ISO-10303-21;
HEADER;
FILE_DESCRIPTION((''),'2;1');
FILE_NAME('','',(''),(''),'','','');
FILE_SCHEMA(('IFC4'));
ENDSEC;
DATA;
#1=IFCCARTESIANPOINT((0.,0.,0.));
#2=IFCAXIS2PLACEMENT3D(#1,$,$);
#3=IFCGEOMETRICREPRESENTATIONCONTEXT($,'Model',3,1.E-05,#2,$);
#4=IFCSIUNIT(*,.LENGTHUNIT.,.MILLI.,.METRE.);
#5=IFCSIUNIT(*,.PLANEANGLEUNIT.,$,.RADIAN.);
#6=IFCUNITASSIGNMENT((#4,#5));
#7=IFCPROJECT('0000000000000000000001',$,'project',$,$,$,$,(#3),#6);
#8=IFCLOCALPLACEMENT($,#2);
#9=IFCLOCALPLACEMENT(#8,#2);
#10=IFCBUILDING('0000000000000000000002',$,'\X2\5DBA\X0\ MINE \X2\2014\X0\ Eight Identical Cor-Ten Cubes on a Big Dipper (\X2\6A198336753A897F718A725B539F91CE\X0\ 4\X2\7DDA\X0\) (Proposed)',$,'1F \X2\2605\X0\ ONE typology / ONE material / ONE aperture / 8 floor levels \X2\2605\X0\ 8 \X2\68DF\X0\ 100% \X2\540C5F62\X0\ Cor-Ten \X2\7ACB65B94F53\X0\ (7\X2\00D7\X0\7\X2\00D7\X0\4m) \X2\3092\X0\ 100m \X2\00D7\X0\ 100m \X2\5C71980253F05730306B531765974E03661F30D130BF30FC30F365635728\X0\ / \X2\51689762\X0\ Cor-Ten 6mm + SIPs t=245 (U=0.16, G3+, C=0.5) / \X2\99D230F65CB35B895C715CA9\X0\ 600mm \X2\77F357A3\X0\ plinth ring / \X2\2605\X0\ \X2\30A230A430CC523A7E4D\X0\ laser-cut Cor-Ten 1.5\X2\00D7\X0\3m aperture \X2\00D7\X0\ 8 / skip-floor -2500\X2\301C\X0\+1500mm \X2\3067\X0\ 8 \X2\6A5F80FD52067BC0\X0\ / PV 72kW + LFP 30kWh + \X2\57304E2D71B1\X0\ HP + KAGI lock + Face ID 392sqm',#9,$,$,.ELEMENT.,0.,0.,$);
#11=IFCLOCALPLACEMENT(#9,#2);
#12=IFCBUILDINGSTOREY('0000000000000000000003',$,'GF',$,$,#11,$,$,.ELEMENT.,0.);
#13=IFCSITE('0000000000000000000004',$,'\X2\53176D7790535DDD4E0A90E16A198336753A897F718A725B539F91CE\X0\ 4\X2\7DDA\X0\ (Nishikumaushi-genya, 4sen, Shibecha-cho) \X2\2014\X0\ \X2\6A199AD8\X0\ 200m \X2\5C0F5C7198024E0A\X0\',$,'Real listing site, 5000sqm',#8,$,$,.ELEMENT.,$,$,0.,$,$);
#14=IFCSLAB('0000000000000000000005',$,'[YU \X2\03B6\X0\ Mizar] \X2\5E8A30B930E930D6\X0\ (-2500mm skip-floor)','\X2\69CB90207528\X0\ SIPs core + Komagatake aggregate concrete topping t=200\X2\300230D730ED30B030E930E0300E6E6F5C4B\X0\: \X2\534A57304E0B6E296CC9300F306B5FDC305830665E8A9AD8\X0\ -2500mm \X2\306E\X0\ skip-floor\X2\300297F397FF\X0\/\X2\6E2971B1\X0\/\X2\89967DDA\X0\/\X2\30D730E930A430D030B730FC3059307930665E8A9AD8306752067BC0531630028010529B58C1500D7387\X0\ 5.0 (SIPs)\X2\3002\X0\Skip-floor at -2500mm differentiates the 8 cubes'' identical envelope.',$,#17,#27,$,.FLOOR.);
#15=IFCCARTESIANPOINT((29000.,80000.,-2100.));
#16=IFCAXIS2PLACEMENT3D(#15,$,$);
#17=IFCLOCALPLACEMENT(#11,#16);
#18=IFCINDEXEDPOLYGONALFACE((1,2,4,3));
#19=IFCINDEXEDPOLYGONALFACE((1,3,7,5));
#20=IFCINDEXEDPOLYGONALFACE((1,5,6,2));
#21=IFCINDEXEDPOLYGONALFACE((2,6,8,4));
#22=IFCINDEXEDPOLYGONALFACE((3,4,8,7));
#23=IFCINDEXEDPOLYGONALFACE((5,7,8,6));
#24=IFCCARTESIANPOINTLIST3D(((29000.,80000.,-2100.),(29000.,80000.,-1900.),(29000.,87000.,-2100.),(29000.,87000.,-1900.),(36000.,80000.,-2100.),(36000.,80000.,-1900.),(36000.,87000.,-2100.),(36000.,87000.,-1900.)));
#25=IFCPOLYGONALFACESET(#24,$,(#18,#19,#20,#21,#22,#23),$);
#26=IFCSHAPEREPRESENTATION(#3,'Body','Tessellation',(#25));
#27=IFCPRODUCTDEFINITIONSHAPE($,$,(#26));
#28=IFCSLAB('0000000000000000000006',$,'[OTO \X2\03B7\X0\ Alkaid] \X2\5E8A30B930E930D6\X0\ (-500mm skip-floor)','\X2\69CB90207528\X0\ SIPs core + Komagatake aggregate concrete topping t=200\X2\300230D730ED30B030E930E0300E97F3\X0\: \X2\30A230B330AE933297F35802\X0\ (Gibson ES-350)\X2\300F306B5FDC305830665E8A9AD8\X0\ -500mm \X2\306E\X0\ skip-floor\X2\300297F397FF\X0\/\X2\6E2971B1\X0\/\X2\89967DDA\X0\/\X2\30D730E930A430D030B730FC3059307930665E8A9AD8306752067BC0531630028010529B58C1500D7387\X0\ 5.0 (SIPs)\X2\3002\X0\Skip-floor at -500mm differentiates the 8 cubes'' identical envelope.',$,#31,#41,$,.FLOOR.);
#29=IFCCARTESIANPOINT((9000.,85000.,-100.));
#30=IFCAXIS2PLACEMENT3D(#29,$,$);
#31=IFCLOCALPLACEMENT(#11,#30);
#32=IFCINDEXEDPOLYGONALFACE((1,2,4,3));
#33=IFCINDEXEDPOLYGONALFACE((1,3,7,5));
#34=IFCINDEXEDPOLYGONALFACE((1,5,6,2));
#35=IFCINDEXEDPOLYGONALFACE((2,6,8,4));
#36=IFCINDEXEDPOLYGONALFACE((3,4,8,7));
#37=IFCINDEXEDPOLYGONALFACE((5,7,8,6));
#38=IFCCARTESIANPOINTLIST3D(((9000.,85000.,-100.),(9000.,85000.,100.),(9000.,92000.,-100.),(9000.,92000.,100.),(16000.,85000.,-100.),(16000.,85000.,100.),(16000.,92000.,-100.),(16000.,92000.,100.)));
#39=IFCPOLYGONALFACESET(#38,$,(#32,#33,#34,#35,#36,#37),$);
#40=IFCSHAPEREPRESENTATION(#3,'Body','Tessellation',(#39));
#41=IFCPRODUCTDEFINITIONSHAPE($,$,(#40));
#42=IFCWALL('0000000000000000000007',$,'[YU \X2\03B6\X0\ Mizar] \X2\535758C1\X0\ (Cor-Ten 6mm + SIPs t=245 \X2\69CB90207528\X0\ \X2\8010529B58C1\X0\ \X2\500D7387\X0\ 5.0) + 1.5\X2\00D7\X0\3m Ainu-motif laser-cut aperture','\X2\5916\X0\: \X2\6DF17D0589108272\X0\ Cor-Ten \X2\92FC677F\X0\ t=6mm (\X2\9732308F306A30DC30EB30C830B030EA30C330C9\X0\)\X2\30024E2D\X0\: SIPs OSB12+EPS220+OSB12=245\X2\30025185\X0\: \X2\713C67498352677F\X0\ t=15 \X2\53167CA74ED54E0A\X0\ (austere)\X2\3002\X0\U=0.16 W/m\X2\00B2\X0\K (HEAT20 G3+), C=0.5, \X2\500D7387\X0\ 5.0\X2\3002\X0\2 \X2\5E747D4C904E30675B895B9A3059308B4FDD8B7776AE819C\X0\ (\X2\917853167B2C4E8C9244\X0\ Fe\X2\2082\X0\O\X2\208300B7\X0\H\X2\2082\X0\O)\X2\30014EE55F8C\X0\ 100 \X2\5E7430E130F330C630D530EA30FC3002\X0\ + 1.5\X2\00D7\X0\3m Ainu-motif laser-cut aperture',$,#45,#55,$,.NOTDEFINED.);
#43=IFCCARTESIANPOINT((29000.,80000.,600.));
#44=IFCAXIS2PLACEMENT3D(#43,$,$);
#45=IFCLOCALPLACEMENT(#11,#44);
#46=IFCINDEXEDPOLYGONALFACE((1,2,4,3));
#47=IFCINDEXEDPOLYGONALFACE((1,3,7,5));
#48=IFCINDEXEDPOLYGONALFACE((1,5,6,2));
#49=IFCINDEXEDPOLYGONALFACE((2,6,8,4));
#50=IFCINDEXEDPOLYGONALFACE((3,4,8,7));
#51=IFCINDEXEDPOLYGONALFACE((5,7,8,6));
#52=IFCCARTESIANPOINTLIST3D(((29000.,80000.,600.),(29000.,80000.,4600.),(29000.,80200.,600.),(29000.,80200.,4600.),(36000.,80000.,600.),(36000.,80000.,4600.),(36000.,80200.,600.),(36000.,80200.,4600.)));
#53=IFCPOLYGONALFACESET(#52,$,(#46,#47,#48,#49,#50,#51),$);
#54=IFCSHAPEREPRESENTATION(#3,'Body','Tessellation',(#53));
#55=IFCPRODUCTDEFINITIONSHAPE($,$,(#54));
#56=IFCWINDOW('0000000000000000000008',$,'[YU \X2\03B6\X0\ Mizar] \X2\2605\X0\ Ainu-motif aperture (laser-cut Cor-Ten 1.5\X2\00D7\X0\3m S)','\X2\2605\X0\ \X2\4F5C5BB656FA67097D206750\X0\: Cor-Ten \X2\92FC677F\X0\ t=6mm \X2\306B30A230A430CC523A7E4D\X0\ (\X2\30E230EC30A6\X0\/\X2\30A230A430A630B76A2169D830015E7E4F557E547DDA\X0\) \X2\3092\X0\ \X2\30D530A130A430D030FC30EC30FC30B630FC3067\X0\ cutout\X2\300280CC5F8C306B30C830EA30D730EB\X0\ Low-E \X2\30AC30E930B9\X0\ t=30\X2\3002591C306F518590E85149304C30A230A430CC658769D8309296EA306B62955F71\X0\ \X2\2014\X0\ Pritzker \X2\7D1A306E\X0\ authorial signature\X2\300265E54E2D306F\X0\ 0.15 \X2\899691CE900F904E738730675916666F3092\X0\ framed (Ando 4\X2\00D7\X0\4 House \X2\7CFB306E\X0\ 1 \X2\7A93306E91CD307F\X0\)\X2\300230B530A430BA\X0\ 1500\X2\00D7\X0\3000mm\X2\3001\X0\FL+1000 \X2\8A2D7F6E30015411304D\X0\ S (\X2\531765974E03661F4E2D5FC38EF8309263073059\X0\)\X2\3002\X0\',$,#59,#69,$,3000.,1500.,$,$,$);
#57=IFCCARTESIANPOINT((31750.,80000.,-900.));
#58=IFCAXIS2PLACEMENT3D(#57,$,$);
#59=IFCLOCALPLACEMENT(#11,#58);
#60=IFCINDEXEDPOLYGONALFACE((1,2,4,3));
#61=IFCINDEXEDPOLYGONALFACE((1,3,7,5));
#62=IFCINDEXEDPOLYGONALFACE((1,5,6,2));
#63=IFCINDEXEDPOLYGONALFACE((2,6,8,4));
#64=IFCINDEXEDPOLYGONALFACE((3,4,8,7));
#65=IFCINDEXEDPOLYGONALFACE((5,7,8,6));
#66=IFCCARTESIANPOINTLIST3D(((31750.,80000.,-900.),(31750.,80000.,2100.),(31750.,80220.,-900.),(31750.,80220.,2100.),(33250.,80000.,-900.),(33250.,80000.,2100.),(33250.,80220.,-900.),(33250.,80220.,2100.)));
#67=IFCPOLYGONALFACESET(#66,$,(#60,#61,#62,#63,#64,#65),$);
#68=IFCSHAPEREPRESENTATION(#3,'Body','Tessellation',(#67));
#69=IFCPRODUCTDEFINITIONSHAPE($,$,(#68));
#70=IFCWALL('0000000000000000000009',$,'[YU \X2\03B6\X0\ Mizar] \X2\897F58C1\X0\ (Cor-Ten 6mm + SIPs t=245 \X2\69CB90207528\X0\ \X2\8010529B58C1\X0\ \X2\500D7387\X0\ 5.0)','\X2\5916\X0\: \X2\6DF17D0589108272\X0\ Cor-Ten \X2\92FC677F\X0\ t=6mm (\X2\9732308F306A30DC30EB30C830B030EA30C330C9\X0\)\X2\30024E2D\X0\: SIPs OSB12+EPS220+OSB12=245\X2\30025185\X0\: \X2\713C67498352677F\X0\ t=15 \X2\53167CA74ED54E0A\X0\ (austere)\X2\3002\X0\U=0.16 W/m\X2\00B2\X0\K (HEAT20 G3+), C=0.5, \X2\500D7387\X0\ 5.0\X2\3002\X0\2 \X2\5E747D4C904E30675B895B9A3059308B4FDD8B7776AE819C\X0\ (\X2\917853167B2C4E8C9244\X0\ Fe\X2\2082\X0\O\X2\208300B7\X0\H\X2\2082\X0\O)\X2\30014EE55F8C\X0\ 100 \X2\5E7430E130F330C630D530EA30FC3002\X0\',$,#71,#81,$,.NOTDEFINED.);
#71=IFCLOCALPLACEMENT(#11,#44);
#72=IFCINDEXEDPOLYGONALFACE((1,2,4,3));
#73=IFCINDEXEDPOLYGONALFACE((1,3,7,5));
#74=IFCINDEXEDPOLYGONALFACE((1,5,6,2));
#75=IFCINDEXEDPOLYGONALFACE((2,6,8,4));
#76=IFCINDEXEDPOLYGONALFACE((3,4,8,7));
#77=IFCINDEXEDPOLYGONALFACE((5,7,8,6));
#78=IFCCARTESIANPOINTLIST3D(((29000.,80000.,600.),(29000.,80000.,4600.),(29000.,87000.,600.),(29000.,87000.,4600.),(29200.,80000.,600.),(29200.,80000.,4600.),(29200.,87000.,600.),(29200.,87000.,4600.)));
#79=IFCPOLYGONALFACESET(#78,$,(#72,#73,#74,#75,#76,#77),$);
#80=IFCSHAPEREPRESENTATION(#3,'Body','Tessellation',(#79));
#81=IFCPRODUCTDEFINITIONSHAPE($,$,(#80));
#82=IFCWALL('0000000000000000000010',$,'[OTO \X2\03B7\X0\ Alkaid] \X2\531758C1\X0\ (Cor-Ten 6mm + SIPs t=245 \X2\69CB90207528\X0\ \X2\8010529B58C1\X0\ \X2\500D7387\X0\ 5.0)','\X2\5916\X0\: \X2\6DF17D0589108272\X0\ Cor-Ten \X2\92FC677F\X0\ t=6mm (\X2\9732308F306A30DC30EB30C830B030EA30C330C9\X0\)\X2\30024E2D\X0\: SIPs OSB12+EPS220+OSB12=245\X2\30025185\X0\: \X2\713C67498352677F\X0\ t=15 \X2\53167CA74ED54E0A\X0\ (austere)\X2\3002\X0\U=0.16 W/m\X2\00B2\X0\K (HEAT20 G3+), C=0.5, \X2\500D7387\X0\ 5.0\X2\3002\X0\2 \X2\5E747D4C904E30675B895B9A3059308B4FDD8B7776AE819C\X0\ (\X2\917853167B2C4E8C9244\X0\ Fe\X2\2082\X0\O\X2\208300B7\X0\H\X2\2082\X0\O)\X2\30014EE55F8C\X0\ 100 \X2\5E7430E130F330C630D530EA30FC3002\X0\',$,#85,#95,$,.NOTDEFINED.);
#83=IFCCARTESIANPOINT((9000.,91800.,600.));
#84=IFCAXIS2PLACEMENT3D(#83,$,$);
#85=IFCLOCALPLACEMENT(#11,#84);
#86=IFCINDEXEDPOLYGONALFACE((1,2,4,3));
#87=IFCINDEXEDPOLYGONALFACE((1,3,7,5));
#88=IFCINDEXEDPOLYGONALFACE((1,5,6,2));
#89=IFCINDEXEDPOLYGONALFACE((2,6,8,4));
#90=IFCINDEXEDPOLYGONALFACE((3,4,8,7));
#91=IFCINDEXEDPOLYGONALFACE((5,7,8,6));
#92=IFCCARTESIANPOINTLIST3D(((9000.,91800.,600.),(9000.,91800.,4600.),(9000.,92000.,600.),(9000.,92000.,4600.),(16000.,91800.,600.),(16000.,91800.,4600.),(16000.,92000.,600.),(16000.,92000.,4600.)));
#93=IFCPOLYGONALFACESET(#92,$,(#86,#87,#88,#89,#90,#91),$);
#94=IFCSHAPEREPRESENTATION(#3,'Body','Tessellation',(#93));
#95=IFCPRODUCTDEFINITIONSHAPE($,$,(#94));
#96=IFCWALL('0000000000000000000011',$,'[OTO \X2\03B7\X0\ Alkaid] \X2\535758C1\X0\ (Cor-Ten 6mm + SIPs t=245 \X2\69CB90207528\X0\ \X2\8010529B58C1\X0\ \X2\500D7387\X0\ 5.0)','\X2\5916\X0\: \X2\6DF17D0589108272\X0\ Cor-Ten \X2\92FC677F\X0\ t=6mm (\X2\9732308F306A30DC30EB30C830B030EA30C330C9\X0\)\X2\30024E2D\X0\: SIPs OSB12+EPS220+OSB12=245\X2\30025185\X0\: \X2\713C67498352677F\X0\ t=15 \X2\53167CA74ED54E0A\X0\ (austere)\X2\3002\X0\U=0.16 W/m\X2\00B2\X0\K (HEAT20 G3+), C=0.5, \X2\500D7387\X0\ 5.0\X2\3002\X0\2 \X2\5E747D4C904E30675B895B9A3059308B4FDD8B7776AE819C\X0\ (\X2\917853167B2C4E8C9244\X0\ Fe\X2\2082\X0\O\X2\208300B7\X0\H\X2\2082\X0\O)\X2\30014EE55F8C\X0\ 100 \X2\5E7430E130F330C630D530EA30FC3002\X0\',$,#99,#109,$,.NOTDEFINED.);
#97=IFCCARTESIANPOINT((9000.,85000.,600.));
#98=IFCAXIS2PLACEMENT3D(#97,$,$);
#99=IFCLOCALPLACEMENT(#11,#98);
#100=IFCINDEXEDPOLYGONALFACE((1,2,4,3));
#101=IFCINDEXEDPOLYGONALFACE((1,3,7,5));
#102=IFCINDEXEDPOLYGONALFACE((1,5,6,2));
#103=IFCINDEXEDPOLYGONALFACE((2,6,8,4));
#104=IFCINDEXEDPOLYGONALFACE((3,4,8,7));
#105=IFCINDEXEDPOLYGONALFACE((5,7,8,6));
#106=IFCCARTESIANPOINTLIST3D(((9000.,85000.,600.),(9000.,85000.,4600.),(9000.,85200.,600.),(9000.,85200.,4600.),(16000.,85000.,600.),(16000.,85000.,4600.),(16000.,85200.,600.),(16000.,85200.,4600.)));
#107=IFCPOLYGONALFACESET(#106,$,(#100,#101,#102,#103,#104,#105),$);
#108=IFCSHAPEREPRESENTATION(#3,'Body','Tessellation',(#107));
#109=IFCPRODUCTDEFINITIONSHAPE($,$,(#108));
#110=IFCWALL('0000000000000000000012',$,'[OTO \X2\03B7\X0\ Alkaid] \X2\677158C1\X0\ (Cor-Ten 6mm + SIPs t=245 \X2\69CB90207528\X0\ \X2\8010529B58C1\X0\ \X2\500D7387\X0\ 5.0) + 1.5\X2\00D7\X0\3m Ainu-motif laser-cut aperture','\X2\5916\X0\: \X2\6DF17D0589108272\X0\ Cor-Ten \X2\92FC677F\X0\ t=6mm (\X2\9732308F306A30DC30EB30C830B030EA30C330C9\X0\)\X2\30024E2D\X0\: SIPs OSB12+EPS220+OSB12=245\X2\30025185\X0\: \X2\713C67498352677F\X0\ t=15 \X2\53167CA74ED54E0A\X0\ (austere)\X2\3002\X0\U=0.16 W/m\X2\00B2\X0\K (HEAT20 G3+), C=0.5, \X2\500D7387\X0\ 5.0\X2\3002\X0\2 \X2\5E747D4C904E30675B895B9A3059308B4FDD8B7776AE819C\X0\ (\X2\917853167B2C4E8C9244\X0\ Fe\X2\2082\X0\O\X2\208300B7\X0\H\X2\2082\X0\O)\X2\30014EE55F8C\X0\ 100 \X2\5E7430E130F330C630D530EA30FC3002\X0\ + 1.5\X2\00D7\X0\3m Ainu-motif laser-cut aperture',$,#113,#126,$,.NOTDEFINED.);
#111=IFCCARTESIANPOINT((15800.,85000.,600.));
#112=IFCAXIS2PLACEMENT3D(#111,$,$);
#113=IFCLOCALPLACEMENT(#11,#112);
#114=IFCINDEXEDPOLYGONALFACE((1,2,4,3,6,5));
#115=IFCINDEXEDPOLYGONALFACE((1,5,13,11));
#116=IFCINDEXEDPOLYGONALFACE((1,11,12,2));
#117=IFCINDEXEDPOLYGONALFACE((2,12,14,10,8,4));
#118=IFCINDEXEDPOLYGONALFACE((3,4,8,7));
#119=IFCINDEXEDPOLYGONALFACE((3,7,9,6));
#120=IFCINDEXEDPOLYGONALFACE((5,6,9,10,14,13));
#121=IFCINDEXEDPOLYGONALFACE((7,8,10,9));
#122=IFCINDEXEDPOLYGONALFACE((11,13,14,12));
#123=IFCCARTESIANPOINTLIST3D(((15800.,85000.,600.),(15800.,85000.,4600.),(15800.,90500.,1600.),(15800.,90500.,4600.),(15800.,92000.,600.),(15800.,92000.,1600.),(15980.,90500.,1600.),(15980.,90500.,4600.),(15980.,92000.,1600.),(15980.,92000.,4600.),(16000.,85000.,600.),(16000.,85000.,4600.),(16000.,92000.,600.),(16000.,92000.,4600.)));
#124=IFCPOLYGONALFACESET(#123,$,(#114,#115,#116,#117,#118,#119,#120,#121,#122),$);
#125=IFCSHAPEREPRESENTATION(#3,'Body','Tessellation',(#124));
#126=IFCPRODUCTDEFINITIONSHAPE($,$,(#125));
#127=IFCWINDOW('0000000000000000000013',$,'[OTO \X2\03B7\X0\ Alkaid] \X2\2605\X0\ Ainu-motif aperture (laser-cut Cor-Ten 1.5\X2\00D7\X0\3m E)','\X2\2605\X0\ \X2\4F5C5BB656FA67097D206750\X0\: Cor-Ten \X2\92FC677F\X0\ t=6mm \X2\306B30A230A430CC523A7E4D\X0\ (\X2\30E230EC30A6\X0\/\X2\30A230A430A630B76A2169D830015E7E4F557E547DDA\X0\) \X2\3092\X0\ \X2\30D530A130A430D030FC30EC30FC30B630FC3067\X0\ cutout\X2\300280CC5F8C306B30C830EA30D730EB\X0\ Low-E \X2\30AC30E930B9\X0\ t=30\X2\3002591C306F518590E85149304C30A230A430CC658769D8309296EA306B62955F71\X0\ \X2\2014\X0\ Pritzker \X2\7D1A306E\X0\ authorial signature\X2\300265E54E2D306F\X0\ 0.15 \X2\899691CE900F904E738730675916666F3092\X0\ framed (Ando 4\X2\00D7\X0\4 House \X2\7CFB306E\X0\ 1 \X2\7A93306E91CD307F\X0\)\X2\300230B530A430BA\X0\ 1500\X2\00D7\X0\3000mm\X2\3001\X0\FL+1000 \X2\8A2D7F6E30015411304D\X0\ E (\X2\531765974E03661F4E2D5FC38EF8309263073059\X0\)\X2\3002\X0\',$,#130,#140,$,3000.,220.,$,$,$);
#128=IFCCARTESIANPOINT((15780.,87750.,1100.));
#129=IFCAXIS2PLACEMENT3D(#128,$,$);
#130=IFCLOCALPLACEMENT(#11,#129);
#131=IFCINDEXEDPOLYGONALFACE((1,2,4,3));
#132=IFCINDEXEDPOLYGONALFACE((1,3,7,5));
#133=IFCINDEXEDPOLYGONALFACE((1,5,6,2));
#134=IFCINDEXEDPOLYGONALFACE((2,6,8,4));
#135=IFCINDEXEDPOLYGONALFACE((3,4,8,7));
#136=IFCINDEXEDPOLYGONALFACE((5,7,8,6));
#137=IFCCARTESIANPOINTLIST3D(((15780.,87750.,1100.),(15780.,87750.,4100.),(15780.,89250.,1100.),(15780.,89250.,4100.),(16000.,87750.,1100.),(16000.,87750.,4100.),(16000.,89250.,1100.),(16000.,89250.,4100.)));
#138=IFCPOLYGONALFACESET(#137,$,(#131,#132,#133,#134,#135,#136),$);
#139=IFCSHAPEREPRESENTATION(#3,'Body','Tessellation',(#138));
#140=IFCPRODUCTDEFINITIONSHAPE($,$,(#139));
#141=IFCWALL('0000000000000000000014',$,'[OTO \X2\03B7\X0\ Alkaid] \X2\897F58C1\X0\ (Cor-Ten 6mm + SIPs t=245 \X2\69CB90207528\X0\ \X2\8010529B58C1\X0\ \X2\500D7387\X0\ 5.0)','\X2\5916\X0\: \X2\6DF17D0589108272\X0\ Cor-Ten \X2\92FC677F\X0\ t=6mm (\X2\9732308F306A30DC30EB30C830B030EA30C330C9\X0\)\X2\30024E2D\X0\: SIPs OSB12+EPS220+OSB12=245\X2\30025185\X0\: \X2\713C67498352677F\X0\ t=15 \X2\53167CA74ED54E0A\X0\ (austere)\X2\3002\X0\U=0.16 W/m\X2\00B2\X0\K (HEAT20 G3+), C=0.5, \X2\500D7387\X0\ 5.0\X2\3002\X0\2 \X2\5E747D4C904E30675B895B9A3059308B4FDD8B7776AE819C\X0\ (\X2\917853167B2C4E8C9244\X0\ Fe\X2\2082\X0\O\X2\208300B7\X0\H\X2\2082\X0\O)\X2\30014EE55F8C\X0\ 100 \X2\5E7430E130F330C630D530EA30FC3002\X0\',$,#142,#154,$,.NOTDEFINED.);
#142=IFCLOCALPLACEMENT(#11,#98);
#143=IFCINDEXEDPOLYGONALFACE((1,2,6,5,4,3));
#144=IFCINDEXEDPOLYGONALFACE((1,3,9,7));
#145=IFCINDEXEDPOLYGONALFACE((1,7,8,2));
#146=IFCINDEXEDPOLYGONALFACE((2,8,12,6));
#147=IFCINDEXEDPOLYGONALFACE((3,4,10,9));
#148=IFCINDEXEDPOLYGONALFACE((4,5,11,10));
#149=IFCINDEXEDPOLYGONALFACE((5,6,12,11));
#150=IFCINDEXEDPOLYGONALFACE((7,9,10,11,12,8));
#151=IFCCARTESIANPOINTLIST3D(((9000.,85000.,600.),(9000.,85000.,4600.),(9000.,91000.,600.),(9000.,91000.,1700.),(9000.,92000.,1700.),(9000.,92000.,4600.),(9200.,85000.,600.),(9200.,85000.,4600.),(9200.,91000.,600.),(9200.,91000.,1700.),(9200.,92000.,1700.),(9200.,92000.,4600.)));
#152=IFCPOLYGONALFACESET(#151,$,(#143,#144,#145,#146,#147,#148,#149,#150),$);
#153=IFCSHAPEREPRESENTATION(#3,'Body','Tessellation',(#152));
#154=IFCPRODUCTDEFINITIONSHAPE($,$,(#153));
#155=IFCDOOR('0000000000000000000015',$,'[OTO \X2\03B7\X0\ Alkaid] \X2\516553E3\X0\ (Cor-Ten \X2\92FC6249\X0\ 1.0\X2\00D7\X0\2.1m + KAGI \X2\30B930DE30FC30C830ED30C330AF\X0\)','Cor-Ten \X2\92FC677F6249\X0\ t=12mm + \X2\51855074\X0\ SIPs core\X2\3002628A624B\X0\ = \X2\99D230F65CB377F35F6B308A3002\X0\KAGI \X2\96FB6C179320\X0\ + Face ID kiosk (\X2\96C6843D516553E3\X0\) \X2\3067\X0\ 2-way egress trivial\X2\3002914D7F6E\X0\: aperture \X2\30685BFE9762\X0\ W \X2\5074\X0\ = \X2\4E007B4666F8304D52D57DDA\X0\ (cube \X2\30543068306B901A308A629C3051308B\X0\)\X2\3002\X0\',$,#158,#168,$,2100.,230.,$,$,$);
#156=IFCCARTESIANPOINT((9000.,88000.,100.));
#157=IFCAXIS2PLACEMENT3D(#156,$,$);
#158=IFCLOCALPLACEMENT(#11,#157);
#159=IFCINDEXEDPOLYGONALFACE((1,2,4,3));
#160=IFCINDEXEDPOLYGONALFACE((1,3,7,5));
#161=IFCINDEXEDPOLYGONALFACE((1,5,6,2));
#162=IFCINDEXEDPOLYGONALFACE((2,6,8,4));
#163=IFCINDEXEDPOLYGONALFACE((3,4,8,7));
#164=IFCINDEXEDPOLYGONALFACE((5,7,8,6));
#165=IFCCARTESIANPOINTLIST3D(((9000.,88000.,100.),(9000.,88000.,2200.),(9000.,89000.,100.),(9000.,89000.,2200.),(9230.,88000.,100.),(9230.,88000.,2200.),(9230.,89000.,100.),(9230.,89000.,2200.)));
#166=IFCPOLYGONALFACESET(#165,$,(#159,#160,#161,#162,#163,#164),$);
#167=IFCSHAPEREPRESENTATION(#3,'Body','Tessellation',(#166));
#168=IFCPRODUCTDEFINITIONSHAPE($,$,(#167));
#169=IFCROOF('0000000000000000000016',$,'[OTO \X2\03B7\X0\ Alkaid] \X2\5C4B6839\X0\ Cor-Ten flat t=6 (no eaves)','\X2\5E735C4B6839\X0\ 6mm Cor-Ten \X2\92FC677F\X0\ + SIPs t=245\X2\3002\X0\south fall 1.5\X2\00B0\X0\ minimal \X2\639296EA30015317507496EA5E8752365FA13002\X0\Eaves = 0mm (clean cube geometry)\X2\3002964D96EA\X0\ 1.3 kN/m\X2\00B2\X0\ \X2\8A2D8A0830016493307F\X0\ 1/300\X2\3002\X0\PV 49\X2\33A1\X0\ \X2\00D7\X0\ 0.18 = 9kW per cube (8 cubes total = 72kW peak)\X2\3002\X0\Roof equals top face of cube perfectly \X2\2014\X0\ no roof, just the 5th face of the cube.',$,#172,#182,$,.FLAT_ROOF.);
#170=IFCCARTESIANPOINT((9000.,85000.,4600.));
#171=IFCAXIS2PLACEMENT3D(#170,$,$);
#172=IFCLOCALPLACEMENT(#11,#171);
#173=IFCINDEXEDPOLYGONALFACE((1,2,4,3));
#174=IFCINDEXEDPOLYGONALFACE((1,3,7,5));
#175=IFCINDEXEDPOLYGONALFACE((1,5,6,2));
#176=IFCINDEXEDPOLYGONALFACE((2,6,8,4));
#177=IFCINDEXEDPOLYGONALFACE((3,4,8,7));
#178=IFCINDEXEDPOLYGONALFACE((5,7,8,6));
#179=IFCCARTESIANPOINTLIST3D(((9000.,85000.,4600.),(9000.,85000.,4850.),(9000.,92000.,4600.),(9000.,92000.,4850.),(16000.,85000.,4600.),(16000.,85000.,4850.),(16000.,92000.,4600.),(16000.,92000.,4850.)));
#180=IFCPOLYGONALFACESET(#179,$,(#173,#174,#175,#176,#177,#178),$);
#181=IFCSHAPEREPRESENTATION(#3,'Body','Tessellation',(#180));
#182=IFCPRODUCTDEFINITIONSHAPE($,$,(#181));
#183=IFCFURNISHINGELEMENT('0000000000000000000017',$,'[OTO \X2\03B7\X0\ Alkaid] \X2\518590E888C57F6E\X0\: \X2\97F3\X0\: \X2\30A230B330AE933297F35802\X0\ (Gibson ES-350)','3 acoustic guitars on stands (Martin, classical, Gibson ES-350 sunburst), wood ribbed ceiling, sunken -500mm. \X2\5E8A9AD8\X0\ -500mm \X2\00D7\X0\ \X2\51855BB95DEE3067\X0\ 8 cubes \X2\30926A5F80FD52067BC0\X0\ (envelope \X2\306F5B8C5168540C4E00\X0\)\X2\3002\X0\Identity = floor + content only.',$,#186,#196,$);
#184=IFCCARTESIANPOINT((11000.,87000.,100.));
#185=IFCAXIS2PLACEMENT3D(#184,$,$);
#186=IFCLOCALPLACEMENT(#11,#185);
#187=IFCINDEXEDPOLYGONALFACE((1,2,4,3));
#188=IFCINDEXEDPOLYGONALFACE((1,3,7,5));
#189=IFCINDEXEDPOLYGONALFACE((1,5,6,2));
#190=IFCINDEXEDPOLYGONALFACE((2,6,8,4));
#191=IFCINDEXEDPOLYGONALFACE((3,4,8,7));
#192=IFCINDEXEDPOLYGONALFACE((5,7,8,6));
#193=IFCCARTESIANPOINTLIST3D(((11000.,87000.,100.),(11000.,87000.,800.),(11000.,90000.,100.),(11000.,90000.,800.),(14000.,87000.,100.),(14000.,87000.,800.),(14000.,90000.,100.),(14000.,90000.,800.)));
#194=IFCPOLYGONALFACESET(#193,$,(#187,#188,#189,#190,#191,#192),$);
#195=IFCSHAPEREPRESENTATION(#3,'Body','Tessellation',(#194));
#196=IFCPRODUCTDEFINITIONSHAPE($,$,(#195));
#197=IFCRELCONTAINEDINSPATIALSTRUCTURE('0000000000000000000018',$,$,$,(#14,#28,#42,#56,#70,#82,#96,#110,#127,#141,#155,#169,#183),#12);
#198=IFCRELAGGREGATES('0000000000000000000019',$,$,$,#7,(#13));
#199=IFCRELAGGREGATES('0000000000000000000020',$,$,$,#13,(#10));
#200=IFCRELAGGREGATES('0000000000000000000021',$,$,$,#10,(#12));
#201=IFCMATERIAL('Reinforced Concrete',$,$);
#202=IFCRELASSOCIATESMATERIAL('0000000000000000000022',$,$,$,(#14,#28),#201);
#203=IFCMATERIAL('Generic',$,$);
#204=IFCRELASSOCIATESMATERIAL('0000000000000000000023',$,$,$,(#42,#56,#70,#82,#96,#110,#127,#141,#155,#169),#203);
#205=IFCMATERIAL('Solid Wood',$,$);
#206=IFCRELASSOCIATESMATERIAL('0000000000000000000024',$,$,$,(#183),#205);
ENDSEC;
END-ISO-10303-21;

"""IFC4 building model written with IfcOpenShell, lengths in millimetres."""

from ifc_helpers import new_model, si_unit, frame, frame_2d, origin, place, context, project, spatial, rectangle, extrude, material, element, fill, save


model = new_model("IFC4")

# Units and contexts
model_context = context("Model", 3, precision=1e-05, world=origin())
ifc_project = project(units=[si_unit("LENGTHUNIT", "METRE", prefix="MILLI"), si_unit("PLANEANGLEUNIT", "RADIAN")], contexts=[model_context])

# Site, building, storey
site_placement = place(None, origin())
site = spatial("IfcSite", under=ifc_project, at=site_placement, Name="北海道川上郡標茶町西熊牛原野 4線 (Nishikumaushi-genya, 4sen, Shibecha-cho) — 標高 200m 小山頂上", ObjectType="Real listing site, 5000sqm", CompositionType="ELEMENT", RefElevation=0.0)
building_placement = place(site_placement, origin())
building = spatial("IfcBuilding", under=site, at=building_placement, Name="嶺 MINE — Eight Identical Cor-Ten Cubes on a Big Dipper (標茶町西熊牛原野 4線) (Proposed)", ObjectType="1F ★ ONE typology / ONE material / ONE aperture / 8 floor levels ★ 8 棟 100% 同形 Cor-Ten 立方体 (7×7×4m) を 100m × 100m 山頂台地に北斗七星パターン散在 / 全面 Cor-Ten 6mm + SIPs t=245 (U=0.16, G3+, C=0.5) / 駒ヶ岳安山岩 600mm 石垣 plinth ring / ★ アイヌ刺繍 laser-cut Cor-Ten 1.5×3m aperture × 8 / skip-floor -2500〜+1500mm で 8 機能分節 / PV 72kW + LFP 30kWh + 地中熱 HP + KAGI lock + Face ID 392sqm", CompositionType="ELEMENT", ElevationOfRefHeight=0.0, ElevationOfTerrain=0.0)
storey_placement = place(building_placement, origin())
storey = spatial("IfcBuildingStorey", under=building, at=storey_placement, Name="GF", CompositionType="ELEMENT", Elevation=0.0)

# Slabs
ifc_material_1 = material(Name="Reinforced Concrete")
slab_1_placement = place(storey_placement, frame((29000.0, 80000.0, -2100.0)))
element("IfcSlab", 1, at=slab_1_placement, inside=storey, material=ifc_material_1, Name="[YU ζ Mizar] 床スラブ (-2500mm skip-floor)", Description="構造用 SIPs core + Komagatake aggregate concrete topping t=200。プログラム『湯屋: 半地下温泉』に応じて床高 -2500mm の skip-floor。音響/温熱/視線/プライバシーすべて床高で分節化。耐力壁倍率 5.0 (SIPs)。Skip-floor at -2500mm differentiates the 8 cubes' identical envelope.", PredefinedType="FLOOR", context=model_context, shape_type="SweptSolid", body=[
    extrude(rectangle(XDim=7000.0, YDim=7000.0, at=frame_2d((3500.0, 3500.0))), frame((29000.0, 80000.0, -2100.0)), (0.0, 0.0, 1.0), 200.0),
])
slab_2_placement = place(storey_placement, frame((9000.0, 85000.0, -100.0)))
element("IfcSlab", 2, at=slab_2_placement, inside=storey, material=ifc_material_1, Name="[OTO η Alkaid] 床スラブ (-500mm skip-floor)", Description="構造用 SIPs core + Komagatake aggregate concrete topping t=200。プログラム『音: アコギ録音堂 (Gibson ES-350)』に応じて床高 -500mm の skip-floor。音響/温熱/視線/プライバシーすべて床高で分節化。耐力壁倍率 5.0 (SIPs)。Skip-floor at -500mm differentiates the 8 cubes' identical envelope.", PredefinedType="FLOOR", context=model_context, shape_type="SweptSolid", body=[
    extrude(rectangle(XDim=7000.0, YDim=7000.0, at=frame_2d((3500.0, 3500.0))), frame((9000.0, 85000.0, -100.0)), (0.0, 0.0, 1.0), 200.0),
])

# Wall, opening, window
ifc_material_2 = material(Name="Generic")
wall_1_placement = place(storey_placement, frame((29000.0, 80000.0, 600.0)))
wall_1 = element("IfcWall", 3, at=wall_1_placement, inside=storey, material=ifc_material_2, Name="[YU ζ Mizar] 南壁 (Cor-Ten 6mm + SIPs t=245 構造用 耐力壁 倍率 5.0) + 1.5×3m Ainu-motif laser-cut aperture", Description="外: 深紅褐色 Cor-Ten 鋼板 t=6mm (露わなボルトグリッド)。中: SIPs OSB12+EPS220+OSB12=245。内: 焼杉荒板 t=15 化粧仕上 (austere)。U=0.16 W/m²K (HEAT20 G3+), C=0.5, 倍率 5.0。2 年経過で安定する保護皮膜 (酸化第二鉄 Fe₂O₃·H₂O)、以後 100 年メンテフリー。 + 1.5×3m Ainu-motif laser-cut aperture", PredefinedType="NOTDEFINED", context=model_context, shape_type="SweptSolid", body=[
    extrude(rectangle(XDim=7000.0, YDim=200.0, at=frame_2d((3500.0, 100.0))), frame((29000.0, 80000.0, 600.0)), (0.0, 0.0, 1.0), 4000.0),
])
opening_1_placement = place(storey_placement, frame((31750.0, 80000.0, -900.0)))
opening_1 = element("IfcOpeningElement", 4, at=opening_1_placement, cuts=wall_1, PredefinedType="NOTDEFINED", context=model_context, shape_type="SweptSolid", body=[
    extrude(rectangle(XDim=1500.0, YDim=220.0, at=frame_2d((750.0, 110.0))), frame((31750.0, 80000.0, -900.0)), (0.0, 0.0, 1.0), 3000.0),
])
window_1_placement = place(storey_placement, frame((31750.0, 80000.0, -900.0)))
window_1 = element("IfcWindow", 5, at=window_1_placement, inside=storey, material=ifc_material_2, Name="[YU ζ Mizar] ★ Ainu-motif aperture (laser-cut Cor-Ten 1.5×3m S)", Description="★ 作家固有素材: Cor-Ten 鋼板 t=6mm にアイヌ刺繍 (モレウ/アイウシ模様、幾何織線) を ファイバーレーザーで cutout。背後にトリプル Low-E ガラス t=30。夜は内部光がアイヌ文様を雪に投影 — Pritzker 級の authorial signature。日中は 0.15 視野透過率で外景を framed (Ando 4×4 House 系の 1 窓の重み)。サイズ 1500×3000mm、FL+1000 設置、向き S (北斗七星中心軸を指す)。", OverallHeight=3000.0, OverallWidth=1500.0, context=model_context, shape_type="SweptSolid", body=[
    extrude(rectangle(XDim=1500.0, YDim=220.0, at=frame_2d((750.0, 110.0))), frame((31750.0, 80000.0, -900.0)), (0.0, 0.0, 1.0), 3000.0),
])
fill(opening_1, window_1)

# Walls
wall_2_placement = place(storey_placement, frame((29000.0, 80000.0, 600.0)))
element("IfcWall", 6, at=wall_2_placement, inside=storey, material=ifc_material_2, Name="[YU ζ Mizar] 西壁 (Cor-Ten 6mm + SIPs t=245 構造用 耐力壁 倍率 5.0)", Description="外: 深紅褐色 Cor-Ten 鋼板 t=6mm (露わなボルトグリッド)。中: SIPs OSB12+EPS220+OSB12=245。内: 焼杉荒板 t=15 化粧仕上 (austere)。U=0.16 W/m²K (HEAT20 G3+), C=0.5, 倍率 5.0。2 年経過で安定する保護皮膜 (酸化第二鉄 Fe₂O₃·H₂O)、以後 100 年メンテフリー。", PredefinedType="NOTDEFINED", context=model_context, shape_type="SweptSolid", body=[
    extrude(rectangle(XDim=200.0, YDim=7000.0, at=frame_2d((100.0, 3500.0))), frame((29000.0, 80000.0, 600.0)), (0.0, 0.0, 1.0), 4000.0),
])
wall_3_placement = place(storey_placement, frame((9000.0, 91800.0, 600.0)))
element("IfcWall", 7, at=wall_3_placement, inside=storey, material=ifc_material_2, Name="[OTO η Alkaid] 北壁 (Cor-Ten 6mm + SIPs t=245 構造用 耐力壁 倍率 5.0)", Description="外: 深紅褐色 Cor-Ten 鋼板 t=6mm (露わなボルトグリッド)。中: SIPs OSB12+EPS220+OSB12=245。内: 焼杉荒板 t=15 化粧仕上 (austere)。U=0.16 W/m²K (HEAT20 G3+), C=0.5, 倍率 5.0。2 年経過で安定する保護皮膜 (酸化第二鉄 Fe₂O₃·H₂O)、以後 100 年メンテフリー。", PredefinedType="NOTDEFINED", context=model_context, shape_type="SweptSolid", body=[
    extrude(rectangle(XDim=7000.0, YDim=200.0, at=frame_2d((3500.0, 100.0))), frame((9000.0, 91800.0, 600.0)), (0.0, 0.0, 1.0), 4000.0),
])
wall_4_placement = place(storey_placement, frame((9000.0, 85000.0, 600.0)))
element("IfcWall", 8, at=wall_4_placement, inside=storey, material=ifc_material_2, Name="[OTO η Alkaid] 南壁 (Cor-Ten 6mm + SIPs t=245 構造用 耐力壁 倍率 5.0)", Description="外: 深紅褐色 Cor-Ten 鋼板 t=6mm (露わなボルトグリッド)。中: SIPs OSB12+EPS220+OSB12=245。内: 焼杉荒板 t=15 化粧仕上 (austere)。U=0.16 W/m²K (HEAT20 G3+), C=0.5, 倍率 5.0。2 年経過で安定する保護皮膜 (酸化第二鉄 Fe₂O₃·H₂O)、以後 100 年メンテフリー。", PredefinedType="NOTDEFINED", context=model_context, shape_type="SweptSolid", body=[
    extrude(rectangle(XDim=7000.0, YDim=200.0, at=frame_2d((3500.0, 100.0))), frame((9000.0, 85000.0, 600.0)), (0.0, 0.0, 1.0), 4000.0),
])

# Wall, opening, window
wall_5_placement = place(storey_placement, frame((15800.0, 85000.0, 600.0)))
wall_5 = element("IfcWall", 9, at=wall_5_placement, inside=storey, material=ifc_material_2, Name="[OTO η Alkaid] 東壁 (Cor-Ten 6mm + SIPs t=245 構造用 耐力壁 倍率 5.0) + 1.5×3m Ainu-motif laser-cut aperture", Description="外: 深紅褐色 Cor-Ten 鋼板 t=6mm (露わなボルトグリッド)。中: SIPs OSB12+EPS220+OSB12=245。内: 焼杉荒板 t=15 化粧仕上 (austere)。U=0.16 W/m²K (HEAT20 G3+), C=0.5, 倍率 5.0。2 年経過で安定する保護皮膜 (酸化第二鉄 Fe₂O₃·H₂O)、以後 100 年メンテフリー。 + 1.5×3m Ainu-motif laser-cut aperture", PredefinedType="NOTDEFINED", context=model_context, shape_type="SweptSolid", body=[
    extrude(rectangle(XDim=200.0, YDim=7000.0, at=frame_2d((100.0, 3500.0))), frame((15800.0, 85000.0, 600.0)), (0.0, 0.0, 1.0), 4000.0),
])
opening_2_placement = place(storey_placement, frame((15780.0, 87750.0, 1100.0)))
opening_2 = element("IfcOpeningElement", 10, at=opening_2_placement, cuts=wall_5, PredefinedType="NOTDEFINED", context=model_context, shape_type="SweptSolid", body=[
    extrude(rectangle(XDim=220.0, YDim=1500.0, at=frame_2d((110.0, 750.0))), frame((15780.0, 87750.0, 1100.0)), (0.0, 0.0, 1.0), 3000.0),
])
window_2_placement = place(storey_placement, frame((15780.0, 87750.0, 1100.0)))
window_2 = element("IfcWindow", 11, at=window_2_placement, inside=storey, material=ifc_material_2, Name="[OTO η Alkaid] ★ Ainu-motif aperture (laser-cut Cor-Ten 1.5×3m E)", Description="★ 作家固有素材: Cor-Ten 鋼板 t=6mm にアイヌ刺繍 (モレウ/アイウシ模様、幾何織線) を ファイバーレーザーで cutout。背後にトリプル Low-E ガラス t=30。夜は内部光がアイヌ文様を雪に投影 — Pritzker 級の authorial signature。日中は 0.15 視野透過率で外景を framed (Ando 4×4 House 系の 1 窓の重み)。サイズ 1500×3000mm、FL+1000 設置、向き E (北斗七星中心軸を指す)。", OverallHeight=3000.0, OverallWidth=220.0, context=model_context, shape_type="SweptSolid", body=[
    extrude(rectangle(XDim=220.0, YDim=1500.0, at=frame_2d((110.0, 750.0))), frame((15780.0, 87750.0, 1100.0)), (0.0, 0.0, 1.0), 3000.0),
])
fill(opening_2, window_2)

# Wall, opening, door
wall_6_placement = place(storey_placement, frame((9000.0, 85000.0, 600.0)))
wall_6 = element("IfcWall", 12, at=wall_6_placement, inside=storey, material=ifc_material_2, Name="[OTO η Alkaid] 西壁 (Cor-Ten 6mm + SIPs t=245 構造用 耐力壁 倍率 5.0)", Description="外: 深紅褐色 Cor-Ten 鋼板 t=6mm (露わなボルトグリッド)。中: SIPs OSB12+EPS220+OSB12=245。内: 焼杉荒板 t=15 化粧仕上 (austere)。U=0.16 W/m²K (HEAT20 G3+), C=0.5, 倍率 5.0。2 年経過で安定する保護皮膜 (酸化第二鉄 Fe₂O₃·H₂O)、以後 100 年メンテフリー。", PredefinedType="NOTDEFINED", context=model_context, shape_type="SweptSolid", body=[
    extrude(rectangle(XDim=200.0, YDim=7000.0, at=frame_2d((100.0, 3500.0))), frame((9000.0, 85000.0, 600.0)), (0.0, 0.0, 1.0), 4000.0),
])
opening_3_placement = place(storey_placement, frame((9000.0, 88000.0, 100.0)))
opening_3 = element("IfcOpeningElement", 13, at=opening_3_placement, cuts=wall_6, PredefinedType="NOTDEFINED", context=model_context, shape_type="SweptSolid", body=[
    extrude(rectangle(XDim=230.0, YDim=1000.0, at=frame_2d((115.0, 500.0))), frame((9000.0, 88000.0, 100.0)), (0.0, 0.0, 1.0), 2100.0),
])
door_placement = place(storey_placement, frame((9000.0, 88000.0, 100.0)))
door = element("IfcDoor", 14, at=door_placement, inside=storey, material=ifc_material_2, Name="[OTO η Alkaid] 入口 (Cor-Ten 鋼扉 1.0×2.1m + KAGI スマートロック)", Description="Cor-Ten 鋼板扉 t=12mm + 内側 SIPs core。把手 = 駒ヶ岳石彫り。KAGI 電気錠 + Face ID kiosk (集落入口) で 2-way egress trivial。配置: aperture と対面 W 側 = 一筆書き動線 (cube ごとに通り抜ける)。", OverallHeight=2100.0, OverallWidth=230.0, context=model_context, shape_type="SweptSolid", body=[
    extrude(rectangle(XDim=230.0, YDim=1000.0, at=frame_2d((115.0, 500.0))), frame((9000.0, 88000.0, 100.0)), (0.0, 0.0, 1.0), 2100.0),
])
fill(opening_3, door)

# Roof
roof_placement = place(storey_placement, frame((9000.0, 85000.0, 4600.0)))
element("IfcRoof", 15, at=roof_placement, inside=storey, material=ifc_material_2, Name="[OTO η Alkaid] 屋根 Cor-Ten flat t=6 (no eaves)", Description="平屋根 6mm Cor-Ten 鋼板 + SIPs t=245。south fall 1.5° minimal 排雪、北側雪庇制御。Eaves = 0mm (clean cube geometry)。降雪 1.3 kN/m² 設計、撓み 1/300。PV 49㎡ × 0.18 = 9kW per cube (8 cubes total = 72kW peak)。Roof equals top face of cube perfectly — no roof, just the 5th face of the cube.", PredefinedType="FLAT_ROOF", context=model_context, shape_type="SweptSolid", body=[
    extrude(rectangle(XDim=7000.0, YDim=7000.0, at=frame_2d((3500.0, 3500.0))), frame((9000.0, 85000.0, 4600.0)), (0.0, 0.0, 1.0), 250.0),
])

# Furnishing element
ifc_material_3 = material(Name="Solid Wood")
furnishing_placement = place(storey_placement, frame((11000.0, 87000.0, 100.0)))
element("IfcFurnishingElement", 16, at=furnishing_placement, inside=storey, material=ifc_material_3, Name="[OTO η Alkaid] 内部装置: 音: アコギ録音堂 (Gibson ES-350)", Description="3 acoustic guitars on stands (Martin, classical, Gibson ES-350 sunburst), wood ribbed ceiling, sunken -500mm. 床高 -500mm × 内容差で 8 cubes を機能分節 (envelope は完全同一)。Identity = floor + content only.", context=model_context, shape_type="SweptSolid", body=[
    extrude(rectangle(XDim=3000.0, YDim=3000.0, at=frame_2d((1500.0, 1500.0))), frame((11000.0, 87000.0, 100.0)), (0.0, 0.0, 1.0), 700.0),
])

save(model, "model.ifc")
